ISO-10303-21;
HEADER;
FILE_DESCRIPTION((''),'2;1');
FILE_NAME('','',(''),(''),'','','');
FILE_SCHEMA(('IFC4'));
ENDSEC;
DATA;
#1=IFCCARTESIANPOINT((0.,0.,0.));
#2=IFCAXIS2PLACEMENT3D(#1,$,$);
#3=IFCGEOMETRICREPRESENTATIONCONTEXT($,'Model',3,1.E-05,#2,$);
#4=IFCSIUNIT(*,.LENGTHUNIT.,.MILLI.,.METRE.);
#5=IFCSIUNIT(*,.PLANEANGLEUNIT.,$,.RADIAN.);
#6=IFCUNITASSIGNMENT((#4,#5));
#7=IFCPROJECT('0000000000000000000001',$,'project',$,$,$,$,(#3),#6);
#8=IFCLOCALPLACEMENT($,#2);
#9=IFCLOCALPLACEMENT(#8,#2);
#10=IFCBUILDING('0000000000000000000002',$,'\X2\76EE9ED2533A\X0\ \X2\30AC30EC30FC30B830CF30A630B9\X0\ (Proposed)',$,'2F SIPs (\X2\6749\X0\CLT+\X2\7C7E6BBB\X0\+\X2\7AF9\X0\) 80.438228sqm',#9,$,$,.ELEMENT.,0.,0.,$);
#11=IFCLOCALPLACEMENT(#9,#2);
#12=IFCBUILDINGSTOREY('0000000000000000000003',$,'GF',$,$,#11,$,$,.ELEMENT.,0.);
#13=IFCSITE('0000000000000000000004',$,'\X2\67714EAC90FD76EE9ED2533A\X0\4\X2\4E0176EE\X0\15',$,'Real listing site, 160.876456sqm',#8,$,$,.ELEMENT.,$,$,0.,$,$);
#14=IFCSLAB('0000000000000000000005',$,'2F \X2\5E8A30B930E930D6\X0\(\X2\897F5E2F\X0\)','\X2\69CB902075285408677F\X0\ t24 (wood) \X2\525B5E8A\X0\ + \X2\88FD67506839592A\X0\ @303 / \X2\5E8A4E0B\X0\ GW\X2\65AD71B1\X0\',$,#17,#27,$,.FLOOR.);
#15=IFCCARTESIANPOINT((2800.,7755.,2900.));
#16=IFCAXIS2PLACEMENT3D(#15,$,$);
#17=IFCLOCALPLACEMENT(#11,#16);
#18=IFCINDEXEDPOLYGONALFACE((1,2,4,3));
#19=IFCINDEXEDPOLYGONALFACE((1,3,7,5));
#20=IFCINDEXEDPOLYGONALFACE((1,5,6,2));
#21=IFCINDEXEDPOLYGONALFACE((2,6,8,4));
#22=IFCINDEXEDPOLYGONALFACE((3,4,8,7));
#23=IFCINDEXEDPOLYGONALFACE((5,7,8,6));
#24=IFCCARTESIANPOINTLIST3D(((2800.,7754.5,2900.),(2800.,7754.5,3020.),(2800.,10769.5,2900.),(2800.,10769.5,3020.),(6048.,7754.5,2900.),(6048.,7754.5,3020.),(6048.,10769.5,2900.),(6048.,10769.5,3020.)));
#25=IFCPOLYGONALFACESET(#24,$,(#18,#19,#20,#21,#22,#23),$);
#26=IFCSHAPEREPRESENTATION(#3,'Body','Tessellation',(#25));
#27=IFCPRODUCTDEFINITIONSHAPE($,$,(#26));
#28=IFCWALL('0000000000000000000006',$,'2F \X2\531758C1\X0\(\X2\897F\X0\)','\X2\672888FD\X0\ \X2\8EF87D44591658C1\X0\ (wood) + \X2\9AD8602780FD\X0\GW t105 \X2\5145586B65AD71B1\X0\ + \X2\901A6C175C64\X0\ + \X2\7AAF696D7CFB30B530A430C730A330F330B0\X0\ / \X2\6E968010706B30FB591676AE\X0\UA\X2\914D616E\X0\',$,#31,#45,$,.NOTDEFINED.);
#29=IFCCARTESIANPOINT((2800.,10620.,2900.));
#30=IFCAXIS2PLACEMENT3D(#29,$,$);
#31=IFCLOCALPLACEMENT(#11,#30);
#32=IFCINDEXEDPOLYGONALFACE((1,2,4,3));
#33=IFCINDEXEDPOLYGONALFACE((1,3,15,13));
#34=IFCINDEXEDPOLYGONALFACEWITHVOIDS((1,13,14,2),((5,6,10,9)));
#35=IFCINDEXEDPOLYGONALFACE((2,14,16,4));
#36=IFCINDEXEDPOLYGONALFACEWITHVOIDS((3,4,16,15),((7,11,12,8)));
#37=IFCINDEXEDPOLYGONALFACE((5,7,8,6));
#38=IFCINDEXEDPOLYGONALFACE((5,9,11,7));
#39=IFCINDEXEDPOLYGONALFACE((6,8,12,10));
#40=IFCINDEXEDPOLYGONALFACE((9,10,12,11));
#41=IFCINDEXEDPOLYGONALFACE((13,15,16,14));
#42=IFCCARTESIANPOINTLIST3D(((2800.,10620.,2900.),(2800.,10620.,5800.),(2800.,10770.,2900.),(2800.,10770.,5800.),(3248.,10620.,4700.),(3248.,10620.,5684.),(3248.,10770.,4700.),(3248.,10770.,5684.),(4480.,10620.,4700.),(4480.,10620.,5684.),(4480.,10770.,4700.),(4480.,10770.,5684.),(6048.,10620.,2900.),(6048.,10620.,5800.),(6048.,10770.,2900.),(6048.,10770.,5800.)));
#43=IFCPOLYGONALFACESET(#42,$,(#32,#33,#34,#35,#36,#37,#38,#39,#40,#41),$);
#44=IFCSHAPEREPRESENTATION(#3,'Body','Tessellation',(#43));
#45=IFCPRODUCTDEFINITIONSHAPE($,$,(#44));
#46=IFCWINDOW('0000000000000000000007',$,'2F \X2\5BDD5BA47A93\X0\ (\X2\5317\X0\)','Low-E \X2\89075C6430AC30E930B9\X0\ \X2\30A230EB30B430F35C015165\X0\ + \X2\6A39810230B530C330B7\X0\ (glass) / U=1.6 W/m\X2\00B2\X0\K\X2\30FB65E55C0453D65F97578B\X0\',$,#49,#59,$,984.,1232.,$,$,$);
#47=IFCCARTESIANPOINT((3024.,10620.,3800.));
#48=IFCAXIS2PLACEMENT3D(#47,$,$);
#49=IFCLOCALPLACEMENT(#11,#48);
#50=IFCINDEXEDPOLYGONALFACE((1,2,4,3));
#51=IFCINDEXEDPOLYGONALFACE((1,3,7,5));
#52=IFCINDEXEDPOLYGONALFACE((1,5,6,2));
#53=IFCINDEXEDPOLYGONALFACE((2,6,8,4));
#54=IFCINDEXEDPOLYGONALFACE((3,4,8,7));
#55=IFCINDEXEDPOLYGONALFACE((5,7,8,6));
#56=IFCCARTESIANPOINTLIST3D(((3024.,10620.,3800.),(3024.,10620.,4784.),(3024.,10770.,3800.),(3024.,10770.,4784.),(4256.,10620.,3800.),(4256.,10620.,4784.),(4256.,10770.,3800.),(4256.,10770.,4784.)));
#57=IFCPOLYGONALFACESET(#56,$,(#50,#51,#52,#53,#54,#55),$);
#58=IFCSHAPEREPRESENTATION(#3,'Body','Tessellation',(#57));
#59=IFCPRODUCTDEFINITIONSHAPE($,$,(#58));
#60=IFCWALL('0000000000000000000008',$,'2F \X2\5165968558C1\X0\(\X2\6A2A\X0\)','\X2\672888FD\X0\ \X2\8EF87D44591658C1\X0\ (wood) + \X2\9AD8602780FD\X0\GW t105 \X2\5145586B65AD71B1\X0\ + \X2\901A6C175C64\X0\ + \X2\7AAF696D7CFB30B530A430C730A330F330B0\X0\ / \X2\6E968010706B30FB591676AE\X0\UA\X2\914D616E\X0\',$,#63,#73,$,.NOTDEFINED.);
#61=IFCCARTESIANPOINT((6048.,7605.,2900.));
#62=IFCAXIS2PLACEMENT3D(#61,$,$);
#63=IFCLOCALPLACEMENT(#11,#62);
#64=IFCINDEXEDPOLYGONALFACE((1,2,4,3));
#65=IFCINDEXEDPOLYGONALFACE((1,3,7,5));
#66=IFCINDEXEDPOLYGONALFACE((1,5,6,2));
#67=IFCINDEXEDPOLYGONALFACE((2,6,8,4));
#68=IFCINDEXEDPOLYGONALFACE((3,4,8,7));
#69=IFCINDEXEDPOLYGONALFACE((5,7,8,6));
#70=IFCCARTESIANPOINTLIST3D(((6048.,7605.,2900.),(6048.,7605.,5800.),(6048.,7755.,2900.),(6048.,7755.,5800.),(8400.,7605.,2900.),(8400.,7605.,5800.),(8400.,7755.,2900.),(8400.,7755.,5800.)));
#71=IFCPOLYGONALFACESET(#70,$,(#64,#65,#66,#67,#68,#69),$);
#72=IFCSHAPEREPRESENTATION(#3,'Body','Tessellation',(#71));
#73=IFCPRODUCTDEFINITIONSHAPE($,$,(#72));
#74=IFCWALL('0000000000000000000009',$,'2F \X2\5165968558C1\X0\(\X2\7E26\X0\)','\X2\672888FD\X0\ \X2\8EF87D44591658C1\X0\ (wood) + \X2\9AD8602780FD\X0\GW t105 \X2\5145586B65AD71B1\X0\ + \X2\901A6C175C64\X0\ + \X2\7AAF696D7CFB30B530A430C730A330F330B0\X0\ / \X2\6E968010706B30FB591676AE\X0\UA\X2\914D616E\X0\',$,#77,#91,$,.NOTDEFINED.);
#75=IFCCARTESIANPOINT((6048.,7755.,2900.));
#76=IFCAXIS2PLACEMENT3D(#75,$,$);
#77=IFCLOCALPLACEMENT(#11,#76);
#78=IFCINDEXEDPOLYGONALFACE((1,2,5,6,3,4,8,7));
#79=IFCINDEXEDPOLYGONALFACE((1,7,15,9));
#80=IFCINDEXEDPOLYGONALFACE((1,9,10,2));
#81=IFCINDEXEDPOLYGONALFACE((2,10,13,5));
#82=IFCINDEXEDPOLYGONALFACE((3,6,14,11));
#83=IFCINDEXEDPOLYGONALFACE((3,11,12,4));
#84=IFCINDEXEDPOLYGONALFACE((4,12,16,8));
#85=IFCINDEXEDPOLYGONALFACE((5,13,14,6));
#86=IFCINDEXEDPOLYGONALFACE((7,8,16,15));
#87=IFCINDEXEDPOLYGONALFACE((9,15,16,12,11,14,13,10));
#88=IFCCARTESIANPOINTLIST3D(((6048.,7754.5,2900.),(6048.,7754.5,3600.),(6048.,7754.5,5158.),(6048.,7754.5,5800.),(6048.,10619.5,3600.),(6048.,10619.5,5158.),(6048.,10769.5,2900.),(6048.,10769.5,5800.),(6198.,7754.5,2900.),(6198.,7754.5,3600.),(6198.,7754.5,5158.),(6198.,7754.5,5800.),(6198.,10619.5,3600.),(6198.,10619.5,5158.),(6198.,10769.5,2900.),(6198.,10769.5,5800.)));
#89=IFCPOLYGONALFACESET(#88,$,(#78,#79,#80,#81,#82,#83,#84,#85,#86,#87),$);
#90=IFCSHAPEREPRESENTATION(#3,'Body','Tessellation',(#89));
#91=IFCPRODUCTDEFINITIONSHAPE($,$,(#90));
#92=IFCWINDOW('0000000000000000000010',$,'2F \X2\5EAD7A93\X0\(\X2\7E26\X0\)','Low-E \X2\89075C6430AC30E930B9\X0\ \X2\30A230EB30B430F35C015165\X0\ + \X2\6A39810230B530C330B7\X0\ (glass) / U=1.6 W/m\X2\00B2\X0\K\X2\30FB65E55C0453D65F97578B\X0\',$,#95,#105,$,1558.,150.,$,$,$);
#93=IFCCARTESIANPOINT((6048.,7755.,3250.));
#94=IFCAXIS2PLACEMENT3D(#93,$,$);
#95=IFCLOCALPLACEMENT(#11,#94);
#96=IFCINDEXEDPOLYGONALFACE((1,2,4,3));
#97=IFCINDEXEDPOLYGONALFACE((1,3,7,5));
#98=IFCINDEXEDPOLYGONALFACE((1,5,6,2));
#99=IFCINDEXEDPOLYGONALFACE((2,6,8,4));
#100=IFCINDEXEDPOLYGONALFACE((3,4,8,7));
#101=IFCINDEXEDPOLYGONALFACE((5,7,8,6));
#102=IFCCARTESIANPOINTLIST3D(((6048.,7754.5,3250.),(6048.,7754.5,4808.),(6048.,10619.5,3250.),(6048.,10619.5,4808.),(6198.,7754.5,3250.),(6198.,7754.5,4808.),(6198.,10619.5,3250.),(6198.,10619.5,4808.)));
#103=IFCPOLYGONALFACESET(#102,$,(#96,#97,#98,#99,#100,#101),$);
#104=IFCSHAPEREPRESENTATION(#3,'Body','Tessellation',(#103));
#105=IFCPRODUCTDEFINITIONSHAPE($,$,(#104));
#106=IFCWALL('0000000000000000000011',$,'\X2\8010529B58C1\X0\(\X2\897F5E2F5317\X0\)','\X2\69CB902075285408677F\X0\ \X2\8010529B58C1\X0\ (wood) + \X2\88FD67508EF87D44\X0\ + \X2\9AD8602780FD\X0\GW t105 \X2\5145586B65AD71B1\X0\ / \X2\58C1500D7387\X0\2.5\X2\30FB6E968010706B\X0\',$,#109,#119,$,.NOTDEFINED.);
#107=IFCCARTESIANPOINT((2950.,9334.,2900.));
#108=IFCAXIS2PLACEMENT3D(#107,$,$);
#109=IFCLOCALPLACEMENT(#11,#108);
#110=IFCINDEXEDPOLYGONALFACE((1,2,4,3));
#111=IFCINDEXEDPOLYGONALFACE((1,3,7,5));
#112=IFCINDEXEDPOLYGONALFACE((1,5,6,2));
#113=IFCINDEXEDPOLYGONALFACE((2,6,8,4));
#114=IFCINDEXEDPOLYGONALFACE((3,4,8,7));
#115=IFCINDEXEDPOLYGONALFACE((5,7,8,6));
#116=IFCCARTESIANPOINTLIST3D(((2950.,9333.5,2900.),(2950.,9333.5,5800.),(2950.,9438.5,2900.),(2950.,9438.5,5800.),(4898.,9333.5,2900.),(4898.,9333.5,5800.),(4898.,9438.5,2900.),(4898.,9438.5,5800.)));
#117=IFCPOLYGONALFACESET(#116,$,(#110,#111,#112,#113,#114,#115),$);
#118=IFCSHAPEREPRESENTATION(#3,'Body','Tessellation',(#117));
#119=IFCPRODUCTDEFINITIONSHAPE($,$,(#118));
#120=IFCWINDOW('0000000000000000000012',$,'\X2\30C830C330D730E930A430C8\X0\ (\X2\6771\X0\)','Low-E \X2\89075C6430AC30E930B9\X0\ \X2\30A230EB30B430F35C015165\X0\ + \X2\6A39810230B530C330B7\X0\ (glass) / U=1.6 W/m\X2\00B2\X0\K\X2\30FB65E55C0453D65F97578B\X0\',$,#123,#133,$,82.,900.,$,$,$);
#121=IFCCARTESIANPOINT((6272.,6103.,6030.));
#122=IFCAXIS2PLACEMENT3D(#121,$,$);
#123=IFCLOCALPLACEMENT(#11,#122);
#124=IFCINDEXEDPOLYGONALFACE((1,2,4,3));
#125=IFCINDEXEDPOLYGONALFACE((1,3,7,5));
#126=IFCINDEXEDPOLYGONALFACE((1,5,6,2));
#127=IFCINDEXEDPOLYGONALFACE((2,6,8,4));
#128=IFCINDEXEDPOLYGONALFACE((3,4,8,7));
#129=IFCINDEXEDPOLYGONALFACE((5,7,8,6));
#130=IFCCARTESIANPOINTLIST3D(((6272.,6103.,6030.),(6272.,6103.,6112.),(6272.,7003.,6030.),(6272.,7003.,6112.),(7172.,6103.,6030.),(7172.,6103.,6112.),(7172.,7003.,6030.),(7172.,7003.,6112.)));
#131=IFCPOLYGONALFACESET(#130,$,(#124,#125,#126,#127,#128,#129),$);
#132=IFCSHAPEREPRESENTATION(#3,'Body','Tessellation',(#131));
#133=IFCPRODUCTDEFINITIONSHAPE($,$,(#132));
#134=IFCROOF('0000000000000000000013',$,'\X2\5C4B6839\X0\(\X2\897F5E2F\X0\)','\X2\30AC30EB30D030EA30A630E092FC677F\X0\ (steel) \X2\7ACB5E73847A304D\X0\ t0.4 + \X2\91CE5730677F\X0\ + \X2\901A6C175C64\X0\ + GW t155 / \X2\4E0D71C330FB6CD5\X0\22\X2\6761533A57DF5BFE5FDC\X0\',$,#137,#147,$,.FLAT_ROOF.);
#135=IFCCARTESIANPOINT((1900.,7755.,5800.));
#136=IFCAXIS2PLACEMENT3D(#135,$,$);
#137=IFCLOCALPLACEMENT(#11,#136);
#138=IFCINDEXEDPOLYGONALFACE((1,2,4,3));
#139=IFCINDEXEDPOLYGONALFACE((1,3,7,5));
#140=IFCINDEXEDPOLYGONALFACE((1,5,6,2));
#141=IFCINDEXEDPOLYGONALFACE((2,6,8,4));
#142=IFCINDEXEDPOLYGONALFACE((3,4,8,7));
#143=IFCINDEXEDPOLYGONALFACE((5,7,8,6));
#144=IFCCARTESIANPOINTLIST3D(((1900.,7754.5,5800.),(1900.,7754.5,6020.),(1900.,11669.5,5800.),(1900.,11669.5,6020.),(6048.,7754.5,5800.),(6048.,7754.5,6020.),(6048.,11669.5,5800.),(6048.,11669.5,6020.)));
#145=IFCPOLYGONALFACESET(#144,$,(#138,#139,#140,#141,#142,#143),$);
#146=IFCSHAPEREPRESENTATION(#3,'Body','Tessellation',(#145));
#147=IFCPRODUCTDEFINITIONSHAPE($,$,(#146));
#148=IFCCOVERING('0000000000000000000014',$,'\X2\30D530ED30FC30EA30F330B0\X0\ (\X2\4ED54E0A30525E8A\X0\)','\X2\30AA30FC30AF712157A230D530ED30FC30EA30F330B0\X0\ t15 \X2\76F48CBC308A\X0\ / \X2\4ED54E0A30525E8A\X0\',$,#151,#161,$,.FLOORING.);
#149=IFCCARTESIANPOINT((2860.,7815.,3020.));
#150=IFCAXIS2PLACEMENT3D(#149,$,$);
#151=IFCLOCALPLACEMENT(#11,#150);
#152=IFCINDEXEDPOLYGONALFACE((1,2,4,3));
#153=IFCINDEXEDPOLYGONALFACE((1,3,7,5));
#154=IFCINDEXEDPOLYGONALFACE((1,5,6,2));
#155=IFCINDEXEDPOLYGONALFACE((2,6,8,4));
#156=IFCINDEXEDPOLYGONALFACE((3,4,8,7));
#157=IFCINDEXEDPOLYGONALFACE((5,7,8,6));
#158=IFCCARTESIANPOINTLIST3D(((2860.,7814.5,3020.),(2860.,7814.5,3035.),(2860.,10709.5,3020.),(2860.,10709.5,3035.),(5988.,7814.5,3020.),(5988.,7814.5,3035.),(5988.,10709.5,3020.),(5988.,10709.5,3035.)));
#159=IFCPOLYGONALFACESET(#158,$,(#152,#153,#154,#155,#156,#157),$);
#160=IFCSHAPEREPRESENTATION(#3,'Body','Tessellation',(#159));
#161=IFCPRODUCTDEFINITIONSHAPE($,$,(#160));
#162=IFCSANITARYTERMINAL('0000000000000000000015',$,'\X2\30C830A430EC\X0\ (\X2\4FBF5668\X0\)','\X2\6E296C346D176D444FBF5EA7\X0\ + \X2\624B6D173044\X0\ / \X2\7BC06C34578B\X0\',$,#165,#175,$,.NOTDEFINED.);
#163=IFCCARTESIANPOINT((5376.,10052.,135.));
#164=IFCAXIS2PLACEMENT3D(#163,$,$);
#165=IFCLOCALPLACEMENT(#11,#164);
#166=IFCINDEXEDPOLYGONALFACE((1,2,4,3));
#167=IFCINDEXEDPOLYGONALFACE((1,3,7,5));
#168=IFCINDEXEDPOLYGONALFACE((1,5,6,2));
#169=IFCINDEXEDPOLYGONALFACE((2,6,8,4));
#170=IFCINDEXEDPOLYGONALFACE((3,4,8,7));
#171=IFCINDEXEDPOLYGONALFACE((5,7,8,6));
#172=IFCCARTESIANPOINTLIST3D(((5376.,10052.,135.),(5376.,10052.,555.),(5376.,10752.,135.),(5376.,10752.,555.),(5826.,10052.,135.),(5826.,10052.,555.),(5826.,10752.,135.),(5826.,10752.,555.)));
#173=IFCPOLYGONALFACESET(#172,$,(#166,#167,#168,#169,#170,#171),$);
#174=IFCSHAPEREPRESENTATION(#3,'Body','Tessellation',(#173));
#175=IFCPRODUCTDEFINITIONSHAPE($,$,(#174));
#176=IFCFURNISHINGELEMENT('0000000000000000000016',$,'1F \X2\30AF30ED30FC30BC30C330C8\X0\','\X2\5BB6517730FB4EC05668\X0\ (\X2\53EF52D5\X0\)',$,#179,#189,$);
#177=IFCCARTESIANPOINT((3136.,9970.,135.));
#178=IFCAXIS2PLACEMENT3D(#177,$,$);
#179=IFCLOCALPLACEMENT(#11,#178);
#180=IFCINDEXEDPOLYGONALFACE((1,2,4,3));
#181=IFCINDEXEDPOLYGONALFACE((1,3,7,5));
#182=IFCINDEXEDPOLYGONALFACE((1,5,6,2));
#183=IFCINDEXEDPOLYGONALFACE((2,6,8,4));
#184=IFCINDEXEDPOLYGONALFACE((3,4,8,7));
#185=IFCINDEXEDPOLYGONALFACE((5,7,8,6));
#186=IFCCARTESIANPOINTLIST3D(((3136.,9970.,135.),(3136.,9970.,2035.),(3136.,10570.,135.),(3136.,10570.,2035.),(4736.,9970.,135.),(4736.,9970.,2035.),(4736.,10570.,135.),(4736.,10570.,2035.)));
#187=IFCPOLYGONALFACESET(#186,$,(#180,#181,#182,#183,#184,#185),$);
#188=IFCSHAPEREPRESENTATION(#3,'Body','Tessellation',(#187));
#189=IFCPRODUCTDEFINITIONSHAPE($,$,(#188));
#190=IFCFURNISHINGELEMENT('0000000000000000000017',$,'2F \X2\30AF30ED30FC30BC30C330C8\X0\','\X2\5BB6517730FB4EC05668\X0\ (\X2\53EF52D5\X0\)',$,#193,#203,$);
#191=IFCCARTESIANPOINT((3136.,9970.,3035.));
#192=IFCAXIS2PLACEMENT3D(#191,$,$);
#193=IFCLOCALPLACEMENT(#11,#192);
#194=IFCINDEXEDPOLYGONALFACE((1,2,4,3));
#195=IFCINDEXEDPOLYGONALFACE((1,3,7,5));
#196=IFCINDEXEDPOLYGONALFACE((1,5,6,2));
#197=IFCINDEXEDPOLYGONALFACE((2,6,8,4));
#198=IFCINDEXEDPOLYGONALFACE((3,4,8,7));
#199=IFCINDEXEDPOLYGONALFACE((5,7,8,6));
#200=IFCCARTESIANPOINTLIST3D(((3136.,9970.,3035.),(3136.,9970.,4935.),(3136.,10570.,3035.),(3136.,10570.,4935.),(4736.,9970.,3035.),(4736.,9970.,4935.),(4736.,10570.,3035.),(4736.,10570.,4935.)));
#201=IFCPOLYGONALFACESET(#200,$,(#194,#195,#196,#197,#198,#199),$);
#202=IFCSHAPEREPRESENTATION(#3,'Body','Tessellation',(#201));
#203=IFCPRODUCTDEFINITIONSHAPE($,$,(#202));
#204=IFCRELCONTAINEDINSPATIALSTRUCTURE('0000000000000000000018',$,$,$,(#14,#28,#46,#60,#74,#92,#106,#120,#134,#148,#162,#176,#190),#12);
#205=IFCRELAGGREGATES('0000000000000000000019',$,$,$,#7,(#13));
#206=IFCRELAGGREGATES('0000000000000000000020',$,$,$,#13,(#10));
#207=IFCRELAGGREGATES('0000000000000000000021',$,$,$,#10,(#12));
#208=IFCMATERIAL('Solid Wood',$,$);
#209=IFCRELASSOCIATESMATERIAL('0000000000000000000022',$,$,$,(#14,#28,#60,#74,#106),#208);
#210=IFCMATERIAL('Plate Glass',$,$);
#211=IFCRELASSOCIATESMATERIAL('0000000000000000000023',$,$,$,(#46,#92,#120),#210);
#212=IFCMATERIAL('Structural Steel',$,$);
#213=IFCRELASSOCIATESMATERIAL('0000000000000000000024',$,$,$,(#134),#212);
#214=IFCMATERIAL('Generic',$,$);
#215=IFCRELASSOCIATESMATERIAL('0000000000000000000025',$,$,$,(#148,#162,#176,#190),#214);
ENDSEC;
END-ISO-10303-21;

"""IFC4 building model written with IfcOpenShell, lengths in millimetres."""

from ifc_helpers import new_model, si_unit, frame, frame_2d, origin, place, context, project, spatial, rectangle, extrude, material, element, fill, save


model = new_model("IFC4")

# Units and contexts
model_context = context("Model", 3, precision=1e-05, world=origin())
ifc_project = project(units=[si_unit("LENGTHUNIT", "METRE", prefix="MILLI"), si_unit("PLANEANGLEUNIT", "RADIAN")], contexts=[model_context])

# Site, building, storey
site_placement = place(None, origin())
site = spatial("IfcSite", under=ifc_project, at=site_placement, Name="東京都目黒区4丁目15", ObjectType="Real listing site, 160.876456sqm", CompositionType="ELEMENT", RefElevation=0.0)
building_placement = place(site_placement, origin())
building = spatial("IfcBuilding", under=site, at=building_placement, Name="目黒区 ガレージハウス (Proposed)", ObjectType="2F SIPs (杉CLT+籾殻+竹) 80.438228sqm", CompositionType="ELEMENT", ElevationOfRefHeight=0.0, ElevationOfTerrain=0.0)
storey_placement = place(building_placement, origin())
storey = spatial("IfcBuildingStorey", under=building, at=storey_placement, Name="GF", CompositionType="ELEMENT", Elevation=0.0)

# Slab
ifc_material_1 = material(Name="Solid Wood")
slab_placement = place(storey_placement, frame((2800.0, 7755.0, 2900.0)))
element("IfcSlab", 1, at=slab_placement, inside=storey, material=ifc_material_1, Name="2F 床スラブ(西帯)", Description="構造用合板 t24 (wood) 剛床 + 製材根太 @303 / 床下 GW断熱", PredefinedType="FLOOR", context=model_context, shape_type="SweptSolid", body=[
    extrude(rectangle(XDim=3248.0, YDim=3015.0, at=frame_2d((1624.0, 1507.0))), frame((2800.0, 7755.0, 2900.0)), (0.0, 0.0, 1.0), 120.0),
])

# Wall, opening, window
wall_1_placement = place(storey_placement, frame((2800.0, 10620.0, 2900.0)))
wall_1 = element("IfcWall", 2, at=wall_1_placement, inside=storey, material=ifc_material_1, Name="2F 北壁(西)", Description="木製 軸組外壁 (wood) + 高性能GW t105 充填断熱 + 通気層 + 窯業系サイディング / 準耐火・外皮UA配慮", PredefinedType="NOTDEFINED", context=model_context, shape_type="SweptSolid", body=[
    extrude(rectangle(XDim=3248.0, YDim=150.0, at=frame_2d((1624.0, 75.0))), frame((2800.0, 10620.0, 2900.0)), (0.0, 0.0, 1.0), 2900.0),
])
opening_1_placement = place(storey_placement, frame((3024.0, 10620.0, 3800.0)))
opening_1 = element("IfcOpeningElement", 3, at=opening_1_placement, cuts=wall_1, PredefinedType="NOTDEFINED", context=model_context, shape_type="SweptSolid", body=[
    extrude(rectangle(XDim=1232.0, YDim=150.0, at=frame_2d((616.0, 75.0))), frame((3024.0, 10620.0, 3800.0)), (0.0, 0.0, 1.0), 984.0),
])
ifc_material_2 = material(Name="Plate Glass")
window_1_placement = place(storey_placement, frame((3024.0, 10620.0, 3800.0)))
window_1 = element("IfcWindow", 4, at=window_1_placement, inside=storey, material=ifc_material_2, Name="2F 寝室窓 (北)", Description="Low-E 複層ガラス アルゴン封入 + 樹脂サッシ (glass) / U=1.6 W/m²K・日射取得型", OverallHeight=984.0, OverallWidth=1232.0, context=model_context, shape_type="SweptSolid", body=[
    extrude(rectangle(XDim=1232.0, YDim=150.0, at=frame_2d((616.0, 75.0))), frame((3024.0, 10620.0, 3800.0)), (0.0, 0.0, 1.0), 984.0),
])
fill(opening_1, window_1)

# Wall
wall_2_placement = place(storey_placement, frame((6048.0, 7605.0, 2900.0)))
element("IfcWall", 5, at=wall_2_placement, inside=storey, material=ifc_material_1, Name="2F 入隅壁(横)", Description="木製 軸組外壁 (wood) + 高性能GW t105 充填断熱 + 通気層 + 窯業系サイディング / 準耐火・外皮UA配慮", PredefinedType="NOTDEFINED", context=model_context, shape_type="SweptSolid", body=[
    extrude(rectangle(XDim=2352.0, YDim=150.0, at=frame_2d((1176.0, 75.0))), frame((6048.0, 7605.0, 2900.0)), (0.0, 0.0, 1.0), 2900.0),
])

# Wall, opening, window
wall_3_placement = place(storey_placement, frame((6048.0, 7755.0, 2900.0)))
wall_3 = element("IfcWall", 6, at=wall_3_placement, inside=storey, material=ifc_material_1, Name="2F 入隅壁(縦)", Description="木製 軸組外壁 (wood) + 高性能GW t105 充填断熱 + 通気層 + 窯業系サイディング / 準耐火・外皮UA配慮", PredefinedType="NOTDEFINED", context=model_context, shape_type="SweptSolid", body=[
    extrude(rectangle(XDim=150.0, YDim=3015.0, at=frame_2d((75.0, 1507.0))), frame((6048.0, 7755.0, 2900.0)), (0.0, 0.0, 1.0), 2900.0),
])
opening_2_placement = place(storey_placement, frame((6048.0, 7755.0, 3250.0)))
opening_2 = element("IfcOpeningElement", 7, at=opening_2_placement, cuts=wall_3, PredefinedType="NOTDEFINED", context=model_context, shape_type="SweptSolid", body=[
    extrude(rectangle(XDim=150.0, YDim=2865.0, at=frame_2d((75.0, 1432.0))), frame((6048.0, 7755.0, 3250.0)), (0.0, 0.0, 1.0), 1558.0),
])
window_2_placement = place(storey_placement, frame((6048.0, 7755.0, 3250.0)))
window_2 = element("IfcWindow", 8, at=window_2_placement, inside=storey, material=ifc_material_2, Name="2F 庭窓(縦)", Description="Low-E 複層ガラス アルゴン封入 + 樹脂サッシ (glass) / U=1.6 W/m²K・日射取得型", OverallHeight=1558.0, OverallWidth=150.0, context=model_context, shape_type="SweptSolid", body=[
    extrude(rectangle(XDim=150.0, YDim=2865.0, at=frame_2d((75.0, 1432.0))), frame((6048.0, 7755.0, 3250.0)), (0.0, 0.0, 1.0), 1558.0),
])
fill(opening_2, window_2)

# Wall
wall_4_placement = place(storey_placement, frame((2950.0, 9334.0, 2900.0)))
element("IfcWall", 9, at=wall_4_placement, inside=storey, material=ifc_material_1, Name="耐力壁(西帯北)", Description="構造用合板 耐力壁 (wood) + 製材軸組 + 高性能GW t105 充填断熱 / 壁倍率2.5・準耐火", PredefinedType="NOTDEFINED", context=model_context, shape_type="SweptSolid", body=[
    extrude(rectangle(XDim=1948.0, YDim=105.0, at=frame_2d((974.0, 52.0))), frame((2950.0, 9334.0, 2900.0)), (0.0, 0.0, 1.0), 2900.0),
])

# Window
window_3_placement = place(storey_placement, frame((6272.0, 6103.0, 6030.0)))
element("IfcWindow", 10, at=window_3_placement, inside=storey, material=ifc_material_2, Name="トップライト (東)", Description="Low-E 複層ガラス アルゴン封入 + 樹脂サッシ (glass) / U=1.6 W/m²K・日射取得型", OverallHeight=82.0, OverallWidth=900.0, context=model_context, shape_type="SweptSolid", body=[
    extrude(rectangle(XDim=900.0, YDim=900.0, at=frame_2d((450.0, 450.0))), frame((6272.0, 6103.0, 6030.0)), (0.0, 0.0, 1.0), 82.0),
])

# Roof
ifc_material_3 = material(Name="Structural Steel")
for number, where, name in (
    (11, (1900.0, 7755.0, 5800.0), "屋根(西帯)"),
):
    element("IfcRoof", number, at=place(storey_placement, frame(where)), inside=storey, material=ifc_material_3, Name=name, Description="ガルバリウム鋼板 (steel) 立平葺き t0.4 + 野地板 + 通気層 + GW t155 / 不燃・法22条区域対応", PredefinedType="FLAT_ROOF", context=model_context, shape_type="SweptSolid", body=[
        extrude(rectangle(XDim=4148.0, YDim=3915.0, at=frame_2d((2074.0, 1957.0))), frame((1900.0, 7755.0, 5800.0)), (0.0, 0.0, 1.0), 220.0),
    ])

# Covering
ifc_material_4 = material(Name="Generic")
covering_placement = place(storey_placement, frame((2860.0, 7815.0, 3020.0)))
element("IfcCovering", 12, at=covering_placement, inside=storey, material=ifc_material_4, Name="フローリング (仕上げ床)", Description="オーク無垢フローリング t15 直貼り / 仕上げ床", PredefinedType="FLOORING", context=model_context, shape_type="SweptSolid", body=[
    extrude(rectangle(XDim=3128.0, YDim=2895.0, at=frame_2d((1564.0, 1447.0))), frame((2860.0, 7815.0, 3020.0)), (0.0, 0.0, 1.0), 15.0),
])

# Sanitary terminal
sanitary_terminal_placement = place(storey_placement, frame((5376.0, 10052.0, 135.0)))
element("IfcSanitaryTerminal", 13, at=sanitary_terminal_placement, inside=storey, material=ifc_material_4, Name="トイレ (便器)", Description="温水洗浄便座 + 手洗い / 節水型", PredefinedType="NOTDEFINED", context=model_context, shape_type="SweptSolid", body=[
    extrude(rectangle(XDim=450.0, YDim=700.0, at=frame_2d((225.0, 350.0))), frame((5376.0, 10052.0, 135.0)), (0.0, 0.0, 1.0), 420.0),
])

# Furnishing elements
furnishing_1_placement = place(storey_placement, frame((3136.0, 9970.0, 135.0)))
element("IfcFurnishingElement", 14, at=furnishing_1_placement, inside=storey, material=ifc_material_4, Name="1F クローゼット", Description="家具・什器 (可動)", context=model_context, shape_type="SweptSolid", body=[
    extrude(rectangle(XDim=1600.0, YDim=600.0, at=frame_2d((800.0, 300.0))), frame((3136.0, 9970.0, 135.0)), (0.0, 0.0, 1.0), 1900.0),
])
furnishing_2_placement = place(storey_placement, frame((3136.0, 9970.0, 3035.0)))
element("IfcFurnishingElement", 15, at=furnishing_2_placement, inside=storey, material=ifc_material_4, Name="2F クローゼット", Description="家具・什器 (可動)", context=model_context, shape_type="SweptSolid", body=[
    extrude(rectangle(XDim=1600.0, YDim=600.0, at=frame_2d((800.0, 300.0))), frame((3136.0, 9970.0, 3035.0)), (0.0, 0.0, 1.0), 1900.0),
])

save(model, "model.ifc")
